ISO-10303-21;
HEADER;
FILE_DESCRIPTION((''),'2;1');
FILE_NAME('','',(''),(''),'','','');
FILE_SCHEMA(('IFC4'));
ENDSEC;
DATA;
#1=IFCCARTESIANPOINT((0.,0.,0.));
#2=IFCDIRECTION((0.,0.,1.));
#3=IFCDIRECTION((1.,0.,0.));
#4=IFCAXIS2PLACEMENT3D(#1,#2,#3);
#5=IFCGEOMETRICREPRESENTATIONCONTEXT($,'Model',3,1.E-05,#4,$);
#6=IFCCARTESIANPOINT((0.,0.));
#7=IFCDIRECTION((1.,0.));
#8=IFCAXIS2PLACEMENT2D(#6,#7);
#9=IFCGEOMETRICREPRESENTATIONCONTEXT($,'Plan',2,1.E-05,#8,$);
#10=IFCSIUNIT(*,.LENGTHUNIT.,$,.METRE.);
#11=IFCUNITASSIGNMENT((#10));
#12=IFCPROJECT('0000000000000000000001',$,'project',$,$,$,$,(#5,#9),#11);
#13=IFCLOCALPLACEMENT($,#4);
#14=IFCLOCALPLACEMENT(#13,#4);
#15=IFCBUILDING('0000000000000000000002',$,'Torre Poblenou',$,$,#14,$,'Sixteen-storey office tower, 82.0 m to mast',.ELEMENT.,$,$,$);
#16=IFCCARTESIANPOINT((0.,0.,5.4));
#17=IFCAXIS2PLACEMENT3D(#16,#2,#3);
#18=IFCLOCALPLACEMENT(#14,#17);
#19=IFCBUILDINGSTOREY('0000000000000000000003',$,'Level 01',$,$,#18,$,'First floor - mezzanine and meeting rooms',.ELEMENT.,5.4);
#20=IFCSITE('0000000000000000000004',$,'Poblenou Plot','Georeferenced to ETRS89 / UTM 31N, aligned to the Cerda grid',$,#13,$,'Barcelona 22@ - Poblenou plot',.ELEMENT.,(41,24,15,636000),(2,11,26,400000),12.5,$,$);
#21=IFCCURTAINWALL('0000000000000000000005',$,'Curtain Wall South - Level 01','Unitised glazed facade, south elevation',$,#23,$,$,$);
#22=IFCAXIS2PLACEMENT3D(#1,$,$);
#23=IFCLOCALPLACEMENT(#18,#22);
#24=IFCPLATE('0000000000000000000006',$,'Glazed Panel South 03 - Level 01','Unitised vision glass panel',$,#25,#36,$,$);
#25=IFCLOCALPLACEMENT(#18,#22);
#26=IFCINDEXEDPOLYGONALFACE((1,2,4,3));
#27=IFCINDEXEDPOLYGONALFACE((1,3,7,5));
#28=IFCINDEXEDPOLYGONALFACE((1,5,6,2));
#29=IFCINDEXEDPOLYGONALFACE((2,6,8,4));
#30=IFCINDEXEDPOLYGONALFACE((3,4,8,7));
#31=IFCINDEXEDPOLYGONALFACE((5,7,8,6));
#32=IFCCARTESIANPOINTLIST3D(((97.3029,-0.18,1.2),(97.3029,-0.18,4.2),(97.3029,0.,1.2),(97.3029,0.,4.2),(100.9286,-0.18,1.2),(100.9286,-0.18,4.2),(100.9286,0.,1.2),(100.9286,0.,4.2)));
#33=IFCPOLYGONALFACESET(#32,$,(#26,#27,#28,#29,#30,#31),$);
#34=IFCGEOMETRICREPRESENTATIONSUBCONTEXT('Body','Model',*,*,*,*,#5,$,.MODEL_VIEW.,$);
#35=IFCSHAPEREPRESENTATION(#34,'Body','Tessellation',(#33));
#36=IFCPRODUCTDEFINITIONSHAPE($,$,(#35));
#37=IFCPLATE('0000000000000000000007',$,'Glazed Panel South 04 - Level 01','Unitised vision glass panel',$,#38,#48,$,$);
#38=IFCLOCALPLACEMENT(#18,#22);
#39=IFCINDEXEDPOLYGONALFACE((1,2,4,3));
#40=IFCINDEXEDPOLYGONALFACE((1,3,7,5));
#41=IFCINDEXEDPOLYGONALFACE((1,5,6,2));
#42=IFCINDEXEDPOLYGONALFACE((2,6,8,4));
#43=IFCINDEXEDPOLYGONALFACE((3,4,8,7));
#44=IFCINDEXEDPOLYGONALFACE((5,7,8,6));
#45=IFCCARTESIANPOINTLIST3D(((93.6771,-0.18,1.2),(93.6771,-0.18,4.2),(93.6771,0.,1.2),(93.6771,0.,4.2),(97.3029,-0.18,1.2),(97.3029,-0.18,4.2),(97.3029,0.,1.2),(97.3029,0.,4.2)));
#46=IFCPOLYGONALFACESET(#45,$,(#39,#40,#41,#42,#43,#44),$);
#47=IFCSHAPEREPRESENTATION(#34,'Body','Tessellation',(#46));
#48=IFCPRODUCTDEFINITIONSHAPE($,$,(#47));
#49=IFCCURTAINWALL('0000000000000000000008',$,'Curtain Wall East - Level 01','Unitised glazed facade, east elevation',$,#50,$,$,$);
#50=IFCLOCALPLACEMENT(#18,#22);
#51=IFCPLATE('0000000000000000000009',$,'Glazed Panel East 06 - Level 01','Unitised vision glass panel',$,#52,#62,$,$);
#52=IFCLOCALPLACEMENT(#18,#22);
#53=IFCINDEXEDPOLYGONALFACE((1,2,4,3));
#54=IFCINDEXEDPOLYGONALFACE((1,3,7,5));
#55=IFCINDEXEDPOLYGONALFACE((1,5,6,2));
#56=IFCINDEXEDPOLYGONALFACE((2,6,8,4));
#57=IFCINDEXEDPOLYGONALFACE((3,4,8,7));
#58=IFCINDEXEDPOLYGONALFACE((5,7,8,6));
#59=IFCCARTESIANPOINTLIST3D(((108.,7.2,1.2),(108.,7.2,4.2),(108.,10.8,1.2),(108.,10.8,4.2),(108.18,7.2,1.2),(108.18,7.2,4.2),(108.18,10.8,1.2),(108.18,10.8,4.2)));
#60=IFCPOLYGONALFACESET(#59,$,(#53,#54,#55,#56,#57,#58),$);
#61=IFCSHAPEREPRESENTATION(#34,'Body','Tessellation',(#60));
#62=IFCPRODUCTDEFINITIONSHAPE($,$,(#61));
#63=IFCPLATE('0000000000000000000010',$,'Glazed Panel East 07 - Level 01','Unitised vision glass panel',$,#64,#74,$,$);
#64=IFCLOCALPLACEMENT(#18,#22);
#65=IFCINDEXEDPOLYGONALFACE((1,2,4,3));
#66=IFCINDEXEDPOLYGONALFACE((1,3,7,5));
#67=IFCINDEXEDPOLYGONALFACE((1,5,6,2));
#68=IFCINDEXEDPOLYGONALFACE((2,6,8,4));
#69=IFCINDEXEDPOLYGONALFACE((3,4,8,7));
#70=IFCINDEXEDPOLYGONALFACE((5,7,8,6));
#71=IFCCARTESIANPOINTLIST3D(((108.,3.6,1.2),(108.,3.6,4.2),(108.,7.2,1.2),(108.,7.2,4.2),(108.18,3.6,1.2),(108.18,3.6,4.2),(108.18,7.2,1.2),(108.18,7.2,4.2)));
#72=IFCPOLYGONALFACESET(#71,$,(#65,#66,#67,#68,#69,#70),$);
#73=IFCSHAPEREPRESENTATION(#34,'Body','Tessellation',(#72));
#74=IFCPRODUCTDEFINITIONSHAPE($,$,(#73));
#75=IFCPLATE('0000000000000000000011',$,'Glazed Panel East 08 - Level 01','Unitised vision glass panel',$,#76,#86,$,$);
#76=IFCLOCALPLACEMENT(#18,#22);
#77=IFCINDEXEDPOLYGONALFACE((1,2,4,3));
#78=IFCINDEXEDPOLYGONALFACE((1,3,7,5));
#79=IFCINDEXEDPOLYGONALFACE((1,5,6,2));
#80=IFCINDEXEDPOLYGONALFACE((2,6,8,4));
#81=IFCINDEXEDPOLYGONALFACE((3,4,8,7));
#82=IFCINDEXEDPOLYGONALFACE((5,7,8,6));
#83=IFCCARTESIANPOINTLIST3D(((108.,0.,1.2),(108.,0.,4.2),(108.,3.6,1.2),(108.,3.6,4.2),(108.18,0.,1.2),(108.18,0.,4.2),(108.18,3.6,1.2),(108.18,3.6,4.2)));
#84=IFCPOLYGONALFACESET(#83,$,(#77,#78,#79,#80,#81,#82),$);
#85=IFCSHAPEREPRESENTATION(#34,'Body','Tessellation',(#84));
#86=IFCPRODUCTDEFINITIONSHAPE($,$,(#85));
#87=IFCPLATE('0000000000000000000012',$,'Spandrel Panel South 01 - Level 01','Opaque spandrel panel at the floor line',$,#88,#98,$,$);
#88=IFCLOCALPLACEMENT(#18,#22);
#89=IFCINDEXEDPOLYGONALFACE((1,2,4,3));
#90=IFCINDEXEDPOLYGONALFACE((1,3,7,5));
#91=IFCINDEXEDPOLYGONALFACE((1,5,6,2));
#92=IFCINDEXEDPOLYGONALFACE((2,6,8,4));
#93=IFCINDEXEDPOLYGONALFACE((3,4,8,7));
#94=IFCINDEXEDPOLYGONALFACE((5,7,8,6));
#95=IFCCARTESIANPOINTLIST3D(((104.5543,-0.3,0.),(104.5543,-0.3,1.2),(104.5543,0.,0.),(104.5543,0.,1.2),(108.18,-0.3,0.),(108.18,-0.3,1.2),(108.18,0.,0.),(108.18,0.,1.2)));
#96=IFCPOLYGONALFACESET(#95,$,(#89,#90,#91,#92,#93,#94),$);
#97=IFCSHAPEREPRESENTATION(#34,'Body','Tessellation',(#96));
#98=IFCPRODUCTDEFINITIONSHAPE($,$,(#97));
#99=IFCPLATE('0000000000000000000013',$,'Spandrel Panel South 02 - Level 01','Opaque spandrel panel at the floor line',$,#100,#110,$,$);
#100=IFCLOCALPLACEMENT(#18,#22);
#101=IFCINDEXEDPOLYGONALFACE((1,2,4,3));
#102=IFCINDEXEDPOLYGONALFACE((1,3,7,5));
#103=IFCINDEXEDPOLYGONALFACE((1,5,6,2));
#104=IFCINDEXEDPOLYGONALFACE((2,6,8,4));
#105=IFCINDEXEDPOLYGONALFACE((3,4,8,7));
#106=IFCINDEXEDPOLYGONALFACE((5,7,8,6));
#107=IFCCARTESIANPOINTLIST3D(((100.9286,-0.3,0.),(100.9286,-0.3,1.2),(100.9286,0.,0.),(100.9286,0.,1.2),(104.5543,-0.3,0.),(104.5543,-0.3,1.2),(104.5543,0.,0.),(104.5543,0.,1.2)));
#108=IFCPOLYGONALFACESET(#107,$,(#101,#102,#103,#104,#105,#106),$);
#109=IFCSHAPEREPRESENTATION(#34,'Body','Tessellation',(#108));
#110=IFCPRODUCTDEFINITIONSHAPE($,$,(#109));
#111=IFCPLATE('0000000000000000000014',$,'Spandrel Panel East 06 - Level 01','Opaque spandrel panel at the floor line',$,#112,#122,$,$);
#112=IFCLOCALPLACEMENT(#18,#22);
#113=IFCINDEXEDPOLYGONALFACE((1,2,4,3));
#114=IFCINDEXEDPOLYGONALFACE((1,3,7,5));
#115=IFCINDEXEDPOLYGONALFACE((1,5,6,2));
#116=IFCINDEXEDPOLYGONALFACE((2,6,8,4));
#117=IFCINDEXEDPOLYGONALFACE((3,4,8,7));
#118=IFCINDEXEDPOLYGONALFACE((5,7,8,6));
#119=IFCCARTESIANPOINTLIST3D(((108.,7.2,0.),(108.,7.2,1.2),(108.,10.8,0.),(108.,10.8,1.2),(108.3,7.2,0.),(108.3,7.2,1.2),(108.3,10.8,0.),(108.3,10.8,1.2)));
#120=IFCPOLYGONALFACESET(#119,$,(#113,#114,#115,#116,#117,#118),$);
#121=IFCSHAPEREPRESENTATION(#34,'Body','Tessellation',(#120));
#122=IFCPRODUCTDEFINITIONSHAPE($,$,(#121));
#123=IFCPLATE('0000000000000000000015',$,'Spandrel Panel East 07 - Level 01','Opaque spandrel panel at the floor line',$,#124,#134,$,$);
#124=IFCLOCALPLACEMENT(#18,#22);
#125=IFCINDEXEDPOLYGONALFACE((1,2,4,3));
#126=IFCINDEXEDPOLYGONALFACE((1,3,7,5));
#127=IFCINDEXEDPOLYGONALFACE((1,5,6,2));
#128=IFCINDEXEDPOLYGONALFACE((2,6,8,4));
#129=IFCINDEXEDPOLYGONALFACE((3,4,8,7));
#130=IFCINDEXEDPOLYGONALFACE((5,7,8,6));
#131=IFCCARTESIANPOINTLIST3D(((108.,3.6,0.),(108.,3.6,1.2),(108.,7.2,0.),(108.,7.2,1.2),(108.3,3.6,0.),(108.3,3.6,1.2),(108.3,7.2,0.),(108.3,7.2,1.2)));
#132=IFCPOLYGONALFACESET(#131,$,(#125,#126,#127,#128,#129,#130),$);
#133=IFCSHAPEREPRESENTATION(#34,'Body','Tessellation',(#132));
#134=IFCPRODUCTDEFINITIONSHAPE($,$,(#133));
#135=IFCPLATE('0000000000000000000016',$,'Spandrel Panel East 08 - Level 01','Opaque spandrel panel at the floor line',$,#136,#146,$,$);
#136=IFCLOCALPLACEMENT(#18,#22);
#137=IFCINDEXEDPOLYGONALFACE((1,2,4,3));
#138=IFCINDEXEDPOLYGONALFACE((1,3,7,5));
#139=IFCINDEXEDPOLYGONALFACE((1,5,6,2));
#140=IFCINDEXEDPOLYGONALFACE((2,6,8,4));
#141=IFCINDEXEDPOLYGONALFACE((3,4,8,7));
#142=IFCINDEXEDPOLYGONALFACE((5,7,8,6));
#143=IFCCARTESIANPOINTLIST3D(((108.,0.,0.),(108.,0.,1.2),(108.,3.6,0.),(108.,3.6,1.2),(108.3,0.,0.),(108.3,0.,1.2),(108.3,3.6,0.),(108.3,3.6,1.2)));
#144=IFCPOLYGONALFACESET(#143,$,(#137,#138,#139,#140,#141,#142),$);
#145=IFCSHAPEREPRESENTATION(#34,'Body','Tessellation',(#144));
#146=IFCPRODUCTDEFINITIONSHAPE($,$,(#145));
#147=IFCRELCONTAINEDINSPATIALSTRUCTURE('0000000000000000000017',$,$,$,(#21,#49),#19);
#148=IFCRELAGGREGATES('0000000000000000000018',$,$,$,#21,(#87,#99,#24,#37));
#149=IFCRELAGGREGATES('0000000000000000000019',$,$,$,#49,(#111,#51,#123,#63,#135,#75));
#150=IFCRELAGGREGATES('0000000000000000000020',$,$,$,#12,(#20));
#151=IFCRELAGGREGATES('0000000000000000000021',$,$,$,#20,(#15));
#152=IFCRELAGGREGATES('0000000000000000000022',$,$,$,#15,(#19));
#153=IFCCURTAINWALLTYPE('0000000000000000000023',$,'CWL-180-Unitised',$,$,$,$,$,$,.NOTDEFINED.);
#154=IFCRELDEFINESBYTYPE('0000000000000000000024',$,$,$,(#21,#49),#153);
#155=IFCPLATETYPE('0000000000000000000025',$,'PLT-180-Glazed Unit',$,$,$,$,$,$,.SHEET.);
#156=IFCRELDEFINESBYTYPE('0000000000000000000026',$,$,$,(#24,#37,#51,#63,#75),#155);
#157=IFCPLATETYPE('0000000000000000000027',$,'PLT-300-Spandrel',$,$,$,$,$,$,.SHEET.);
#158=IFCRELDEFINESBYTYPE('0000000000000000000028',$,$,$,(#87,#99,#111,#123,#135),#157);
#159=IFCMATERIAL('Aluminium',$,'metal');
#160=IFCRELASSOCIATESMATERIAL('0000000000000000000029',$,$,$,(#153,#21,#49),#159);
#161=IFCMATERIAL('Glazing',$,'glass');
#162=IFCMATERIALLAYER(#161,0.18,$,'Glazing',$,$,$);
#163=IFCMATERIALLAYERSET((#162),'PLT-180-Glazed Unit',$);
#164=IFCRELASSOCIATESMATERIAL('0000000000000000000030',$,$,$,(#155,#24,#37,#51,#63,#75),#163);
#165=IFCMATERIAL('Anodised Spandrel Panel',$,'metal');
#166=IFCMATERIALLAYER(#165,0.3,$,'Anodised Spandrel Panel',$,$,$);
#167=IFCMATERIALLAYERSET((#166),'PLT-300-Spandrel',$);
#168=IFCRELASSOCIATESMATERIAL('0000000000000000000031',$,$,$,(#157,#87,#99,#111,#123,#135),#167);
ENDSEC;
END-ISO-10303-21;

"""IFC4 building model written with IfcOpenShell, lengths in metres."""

from ifc_helpers import new_model, si_unit, frame, origin_with_axes, origin_2d_with_axis, place, context, subcontext, project, spatial, line, indexed_curve, outline, extrude, material, layer, layer_set, layer_usage, type_object, element, aggregate, save


model = new_model("IFC4")

# Units and contexts
model_context = context("Model", 3, precision=1e-05, world=origin_with_axes())
plan_context = context("Plan", 2, precision=1e-05, world=origin_2d_with_axis())
body_context = subcontext(model_context, "Body", "Model", "MODEL_VIEW")
ifc_project = project(units=[si_unit("LENGTHUNIT", "METRE")], contexts=[model_context, plan_context])

# Site, building, storey
site_placement = place(None, origin_with_axes())
site = spatial("IfcSite", under=ifc_project, at=site_placement, Name="Poblenou Plot", Description="Georeferenced to ETRS89 / UTM 31N, aligned to the Cerda grid", LongName="Barcelona 22@ - Poblenou plot", CompositionType="ELEMENT", RefLatitude=(41, 24, 15, 636000), RefLongitude=(2, 11, 26, 400000), RefElevation=12.5)
building_placement = place(site_placement, origin_with_axes())
building = spatial("IfcBuilding", under=site, at=building_placement, Name="Torre Poblenou", LongName="Sixteen-storey office tower, 82.0 m to mast", CompositionType="ELEMENT")
storey_placement = place(building_placement, frame((0.0, 0.0, 5.4), z_axis=(0.0, 0.0, 1.0), x_axis=(1.0, 0.0, 0.0)))
storey = spatial("IfcBuildingStorey", under=building, at=storey_placement, Name="Level 01", LongName="First floor - mezzanine and meeting rooms", CompositionType="ELEMENT", Elevation=5.4)

# Curtain walls, plates
ifc_material_1 = material(Name="Aluminium", Category="metal")
curtain_wall_type = type_object("IfcCurtainWallType", Name="CWL-180-Unitised", PredefinedType="NOTDEFINED", material=ifc_material_1)
curtain_wall_1_placement = place(storey_placement, frame((108.18, 0.0, 0.0), z_axis=(0.0, 0.0, 1.0), x_axis=(-1.0, 0.0, 0.0)))
curtain_wall_1 = element("IfcCurtainWall", 1, at=curtain_wall_1_placement, inside=storey, type_object=curtain_wall_type, material=ifc_material_1, Name="Curtain Wall South - Level 01", Description="Unitised glazed facade, south elevation")
ifc_material_2 = material(Name="Glazing", Category="glass")
ifc_layer_1 = layer(ifc_material_2, 0.18, Name="Glazing")
ifc_layer_set_1 = layer_set([ifc_layer_1], Name="PLT-180-Glazed Unit")
plate_type_1 = type_object("IfcPlateType", Name="PLT-180-Glazed Unit", PredefinedType="SHEET", material=ifc_layer_set_1)
ifc_layer_usage_1 = layer_usage(ifc_layer_set_1, "AXIS2", "POSITIVE", 0.0)
plate_1_placement = place(curtain_wall_1_placement, frame((7.2514, 0.0, 1.2), z_axis=(0.0, 0.0, 1.0), x_axis=(1.0, 0.0, 0.0)))
plate_1 = element("IfcPlate", 2, at=plate_1_placement, type_object=plate_type_1, material=ifc_layer_usage_1, Name="Glazed Panel South 03 - Level 01", Description="Unitised vision glass panel", context=body_context, shape_type="SweptSolid", body=[
    extrude(outline(indexed_curve([(0.0, 0.0), (3.6257, 0.0), (3.6257, 0.18), (0.0, 0.18)], segments=[line(1, 2, 3, 4, 1)])), origin_with_axes(), (0.0, 0.0, 1.0), 3.0),
])
ifc_layer_usage_2 = layer_usage(ifc_layer_set_1, "AXIS2", "POSITIVE", 0.0)
plate_2_placement = place(curtain_wall_1_placement, frame((10.8771, 0.0, 1.2), z_axis=(0.0, 0.0, 1.0), x_axis=(1.0, 0.0, 0.0)))
plate_2 = element("IfcPlate", 3, at=plate_2_placement, type_object=plate_type_1, material=ifc_layer_usage_2, Name="Glazed Panel South 04 - Level 01", Description="Unitised vision glass panel", context=body_context, shape_type="SweptSolid", body=[
    extrude(outline(indexed_curve([(0.0, 0.0), (3.6257, 0.0), (3.6257, 0.18), (0.0, 0.18)], segments=[line(1, 2, 3, 4, 1)])), origin_with_axes(), (0.0, 0.0, 1.0), 3.0),
])
curtain_wall_2_placement = place(storey_placement, frame((108.0, 28.8, 0.0), z_axis=(0.0, 0.0, 1.0), x_axis=(0.0, -1.0, 0.0)))
curtain_wall_2 = element("IfcCurtainWall", 4, at=curtain_wall_2_placement, inside=storey, type_object=curtain_wall_type, material=ifc_material_1, Name="Curtain Wall East - Level 01", Description="Unitised glazed facade, east elevation")
ifc_layer_usage_3 = layer_usage(ifc_layer_set_1, "AXIS2", "POSITIVE", 0.0)
plate_3_placement = place(curtain_wall_2_placement, frame((18.0, 0.0, 1.2), z_axis=(0.0, 0.0, 1.0), x_axis=(1.0, 0.0, 0.0)))
plate_3 = element("IfcPlate", 5, at=plate_3_placement, type_object=plate_type_1, material=ifc_layer_usage_3, Name="Glazed Panel East 06 - Level 01", Description="Unitised vision glass panel", context=body_context, shape_type="SweptSolid", body=[
    extrude(outline(indexed_curve([(0.0, 0.0), (3.6, 0.0), (3.6, 0.18), (0.0, 0.18)], segments=[line(1, 2, 3, 4, 1)])), origin_with_axes(), (0.0, 0.0, 1.0), 3.0),
])
ifc_layer_usage_4 = layer_usage(ifc_layer_set_1, "AXIS2", "POSITIVE", 0.0)
plate_4_placement = place(curtain_wall_2_placement, frame((21.6, 0.0, 1.2), z_axis=(0.0, 0.0, 1.0), x_axis=(1.0, 0.0, 0.0)))
plate_4 = element("IfcPlate", 6, at=plate_4_placement, type_object=plate_type_1, material=ifc_layer_usage_4, Name="Glazed Panel East 07 - Level 01", Description="Unitised vision glass panel", context=body_context, shape_type="SweptSolid", body=[
    extrude(outline(indexed_curve([(0.0, 0.0), (3.6, 0.0), (3.6, 0.18), (0.0, 0.18)], segments=[line(1, 2, 3, 4, 1)])), origin_with_axes(), (0.0, 0.0, 1.0), 3.0),
])
ifc_layer_usage_5 = layer_usage(ifc_layer_set_1, "AXIS2", "POSITIVE", 0.0)
plate_5_placement = place(curtain_wall_2_placement, frame((25.2, 0.0, 1.2), z_axis=(0.0, 0.0, 1.0), x_axis=(1.0, 0.0, 0.0)))
plate_5 = element("IfcPlate", 7, at=plate_5_placement, type_object=plate_type_1, material=ifc_layer_usage_5, Name="Glazed Panel East 08 - Level 01", Description="Unitised vision glass panel", context=body_context, shape_type="SweptSolid", body=[
    extrude(outline(indexed_curve([(0.0, 0.0), (3.6, 0.0), (3.6, 0.18), (0.0, 0.18)], segments=[line(1, 2, 3, 4, 1)])), origin_with_axes(), (0.0, 0.0, 1.0), 3.0),
])

# Plates
ifc_material_3 = material(Name="Anodised Spandrel Panel", Category="metal")
ifc_layer_2 = layer(ifc_material_3, 0.3, Name="Anodised Spandrel Panel")
ifc_layer_set_2 = layer_set([ifc_layer_2], Name="PLT-300-Spandrel")
ifc_layer_usage_6 = layer_usage(ifc_layer_set_2, "AXIS2", "POSITIVE", 0.0)
plate_type_2 = type_object("IfcPlateType", Name="PLT-300-Spandrel", PredefinedType="SHEET", material=ifc_layer_set_2)
plate_6_placement = place(curtain_wall_1_placement, origin_with_axes())
plate_6 = element("IfcPlate", 8, at=plate_6_placement, type_object=plate_type_2, material=ifc_layer_usage_6, Name="Spandrel Panel South 01 - Level 01", Description="Opaque spandrel panel at the floor line", context=body_context, shape_type="SweptSolid", body=[
    extrude(outline(indexed_curve([(0.0, 0.0), (3.6257, 0.0), (3.6257, 0.3), (0.0, 0.3)], segments=[line(1, 2, 3, 4, 1)])), origin_with_axes(), (0.0, 0.0, 1.0), 1.2),
])
ifc_layer_usage_7 = layer_usage(ifc_layer_set_2, "AXIS2", "POSITIVE", 0.0)
plate_7_placement = place(curtain_wall_1_placement, frame((3.6257, 0.0, 0.0), z_axis=(0.0, 0.0, 1.0), x_axis=(1.0, 0.0, 0.0)))
plate_7 = element("IfcPlate", 9, at=plate_7_placement, type_object=plate_type_2, material=ifc_layer_usage_7, Name="Spandrel Panel South 02 - Level 01", Description="Opaque spandrel panel at the floor line", context=body_context, shape_type="SweptSolid", body=[
    extrude(outline(indexed_curve([(0.0, 0.0), (3.6257, 0.0), (3.6257, 0.3), (0.0, 0.3)], segments=[line(1, 2, 3, 4, 1)])), origin_with_axes(), (0.0, 0.0, 1.0), 1.2),
])
aggregate(curtain_wall_1, [plate_6, plate_7, plate_1, plate_2])
ifc_layer_usage_8 = layer_usage(ifc_layer_set_2, "AXIS2", "POSITIVE", 0.0)
plate_8_placement = place(curtain_wall_2_placement, frame((18.0, 0.0, 0.0), z_axis=(0.0, 0.0, 1.0), x_axis=(1.0, 0.0, 0.0)))
plate_8 = element("IfcPlate", 10, at=plate_8_placement, type_object=plate_type_2, material=ifc_layer_usage_8, Name="Spandrel Panel East 06 - Level 01", Description="Opaque spandrel panel at the floor line", context=body_context, shape_type="SweptSolid", body=[
    extrude(outline(indexed_curve([(0.0, 0.0), (3.6, 0.0), (3.6, 0.3), (0.0, 0.3)], segments=[line(1, 2, 3, 4, 1)])), origin_with_axes(), (0.0, 0.0, 1.0), 1.2),
])
ifc_layer_usage_9 = layer_usage(ifc_layer_set_2, "AXIS2", "POSITIVE", 0.0)
plate_9_placement = place(curtain_wall_2_placement, frame((21.6, 0.0, 0.0), z_axis=(0.0, 0.0, 1.0), x_axis=(1.0, 0.0, 0.0)))
plate_9 = element("IfcPlate", 11, at=plate_9_placement, type_object=plate_type_2, material=ifc_layer_usage_9, Name="Spandrel Panel East 07 - Level 01", Description="Opaque spandrel panel at the floor line", context=body_context, shape_type="SweptSolid", body=[
    extrude(outline(indexed_curve([(0.0, 0.0), (3.6, 0.0), (3.6, 0.3), (0.0, 0.3)], segments=[line(1, 2, 3, 4, 1)])), origin_with_axes(), (0.0, 0.0, 1.0), 1.2),
])
ifc_layer_usage_10 = layer_usage(ifc_layer_set_2, "AXIS2", "POSITIVE", 0.0)
plate_10_placement = place(curtain_wall_2_placement, frame((25.2, 0.0, 0.0), z_axis=(0.0, 0.0, 1.0), x_axis=(1.0, 0.0, 0.0)))
plate_10 = element("IfcPlate", 12, at=plate_10_placement, type_object=plate_type_2, material=ifc_layer_usage_10, Name="Spandrel Panel East 08 - Level 01", Description="Opaque spandrel panel at the floor line", context=body_context, shape_type="SweptSolid", body=[
    extrude(outline(indexed_curve([(0.0, 0.0), (3.6, 0.0), (3.6, 0.3), (0.0, 0.3)], segments=[line(1, 2, 3, 4, 1)])), origin_with_axes(), (0.0, 0.0, 1.0), 1.2),
])
aggregate(curtain_wall_2, [plate_8, plate_3, plate_9, plate_4, plate_10, plate_5])

save(model, "model.ifc")
